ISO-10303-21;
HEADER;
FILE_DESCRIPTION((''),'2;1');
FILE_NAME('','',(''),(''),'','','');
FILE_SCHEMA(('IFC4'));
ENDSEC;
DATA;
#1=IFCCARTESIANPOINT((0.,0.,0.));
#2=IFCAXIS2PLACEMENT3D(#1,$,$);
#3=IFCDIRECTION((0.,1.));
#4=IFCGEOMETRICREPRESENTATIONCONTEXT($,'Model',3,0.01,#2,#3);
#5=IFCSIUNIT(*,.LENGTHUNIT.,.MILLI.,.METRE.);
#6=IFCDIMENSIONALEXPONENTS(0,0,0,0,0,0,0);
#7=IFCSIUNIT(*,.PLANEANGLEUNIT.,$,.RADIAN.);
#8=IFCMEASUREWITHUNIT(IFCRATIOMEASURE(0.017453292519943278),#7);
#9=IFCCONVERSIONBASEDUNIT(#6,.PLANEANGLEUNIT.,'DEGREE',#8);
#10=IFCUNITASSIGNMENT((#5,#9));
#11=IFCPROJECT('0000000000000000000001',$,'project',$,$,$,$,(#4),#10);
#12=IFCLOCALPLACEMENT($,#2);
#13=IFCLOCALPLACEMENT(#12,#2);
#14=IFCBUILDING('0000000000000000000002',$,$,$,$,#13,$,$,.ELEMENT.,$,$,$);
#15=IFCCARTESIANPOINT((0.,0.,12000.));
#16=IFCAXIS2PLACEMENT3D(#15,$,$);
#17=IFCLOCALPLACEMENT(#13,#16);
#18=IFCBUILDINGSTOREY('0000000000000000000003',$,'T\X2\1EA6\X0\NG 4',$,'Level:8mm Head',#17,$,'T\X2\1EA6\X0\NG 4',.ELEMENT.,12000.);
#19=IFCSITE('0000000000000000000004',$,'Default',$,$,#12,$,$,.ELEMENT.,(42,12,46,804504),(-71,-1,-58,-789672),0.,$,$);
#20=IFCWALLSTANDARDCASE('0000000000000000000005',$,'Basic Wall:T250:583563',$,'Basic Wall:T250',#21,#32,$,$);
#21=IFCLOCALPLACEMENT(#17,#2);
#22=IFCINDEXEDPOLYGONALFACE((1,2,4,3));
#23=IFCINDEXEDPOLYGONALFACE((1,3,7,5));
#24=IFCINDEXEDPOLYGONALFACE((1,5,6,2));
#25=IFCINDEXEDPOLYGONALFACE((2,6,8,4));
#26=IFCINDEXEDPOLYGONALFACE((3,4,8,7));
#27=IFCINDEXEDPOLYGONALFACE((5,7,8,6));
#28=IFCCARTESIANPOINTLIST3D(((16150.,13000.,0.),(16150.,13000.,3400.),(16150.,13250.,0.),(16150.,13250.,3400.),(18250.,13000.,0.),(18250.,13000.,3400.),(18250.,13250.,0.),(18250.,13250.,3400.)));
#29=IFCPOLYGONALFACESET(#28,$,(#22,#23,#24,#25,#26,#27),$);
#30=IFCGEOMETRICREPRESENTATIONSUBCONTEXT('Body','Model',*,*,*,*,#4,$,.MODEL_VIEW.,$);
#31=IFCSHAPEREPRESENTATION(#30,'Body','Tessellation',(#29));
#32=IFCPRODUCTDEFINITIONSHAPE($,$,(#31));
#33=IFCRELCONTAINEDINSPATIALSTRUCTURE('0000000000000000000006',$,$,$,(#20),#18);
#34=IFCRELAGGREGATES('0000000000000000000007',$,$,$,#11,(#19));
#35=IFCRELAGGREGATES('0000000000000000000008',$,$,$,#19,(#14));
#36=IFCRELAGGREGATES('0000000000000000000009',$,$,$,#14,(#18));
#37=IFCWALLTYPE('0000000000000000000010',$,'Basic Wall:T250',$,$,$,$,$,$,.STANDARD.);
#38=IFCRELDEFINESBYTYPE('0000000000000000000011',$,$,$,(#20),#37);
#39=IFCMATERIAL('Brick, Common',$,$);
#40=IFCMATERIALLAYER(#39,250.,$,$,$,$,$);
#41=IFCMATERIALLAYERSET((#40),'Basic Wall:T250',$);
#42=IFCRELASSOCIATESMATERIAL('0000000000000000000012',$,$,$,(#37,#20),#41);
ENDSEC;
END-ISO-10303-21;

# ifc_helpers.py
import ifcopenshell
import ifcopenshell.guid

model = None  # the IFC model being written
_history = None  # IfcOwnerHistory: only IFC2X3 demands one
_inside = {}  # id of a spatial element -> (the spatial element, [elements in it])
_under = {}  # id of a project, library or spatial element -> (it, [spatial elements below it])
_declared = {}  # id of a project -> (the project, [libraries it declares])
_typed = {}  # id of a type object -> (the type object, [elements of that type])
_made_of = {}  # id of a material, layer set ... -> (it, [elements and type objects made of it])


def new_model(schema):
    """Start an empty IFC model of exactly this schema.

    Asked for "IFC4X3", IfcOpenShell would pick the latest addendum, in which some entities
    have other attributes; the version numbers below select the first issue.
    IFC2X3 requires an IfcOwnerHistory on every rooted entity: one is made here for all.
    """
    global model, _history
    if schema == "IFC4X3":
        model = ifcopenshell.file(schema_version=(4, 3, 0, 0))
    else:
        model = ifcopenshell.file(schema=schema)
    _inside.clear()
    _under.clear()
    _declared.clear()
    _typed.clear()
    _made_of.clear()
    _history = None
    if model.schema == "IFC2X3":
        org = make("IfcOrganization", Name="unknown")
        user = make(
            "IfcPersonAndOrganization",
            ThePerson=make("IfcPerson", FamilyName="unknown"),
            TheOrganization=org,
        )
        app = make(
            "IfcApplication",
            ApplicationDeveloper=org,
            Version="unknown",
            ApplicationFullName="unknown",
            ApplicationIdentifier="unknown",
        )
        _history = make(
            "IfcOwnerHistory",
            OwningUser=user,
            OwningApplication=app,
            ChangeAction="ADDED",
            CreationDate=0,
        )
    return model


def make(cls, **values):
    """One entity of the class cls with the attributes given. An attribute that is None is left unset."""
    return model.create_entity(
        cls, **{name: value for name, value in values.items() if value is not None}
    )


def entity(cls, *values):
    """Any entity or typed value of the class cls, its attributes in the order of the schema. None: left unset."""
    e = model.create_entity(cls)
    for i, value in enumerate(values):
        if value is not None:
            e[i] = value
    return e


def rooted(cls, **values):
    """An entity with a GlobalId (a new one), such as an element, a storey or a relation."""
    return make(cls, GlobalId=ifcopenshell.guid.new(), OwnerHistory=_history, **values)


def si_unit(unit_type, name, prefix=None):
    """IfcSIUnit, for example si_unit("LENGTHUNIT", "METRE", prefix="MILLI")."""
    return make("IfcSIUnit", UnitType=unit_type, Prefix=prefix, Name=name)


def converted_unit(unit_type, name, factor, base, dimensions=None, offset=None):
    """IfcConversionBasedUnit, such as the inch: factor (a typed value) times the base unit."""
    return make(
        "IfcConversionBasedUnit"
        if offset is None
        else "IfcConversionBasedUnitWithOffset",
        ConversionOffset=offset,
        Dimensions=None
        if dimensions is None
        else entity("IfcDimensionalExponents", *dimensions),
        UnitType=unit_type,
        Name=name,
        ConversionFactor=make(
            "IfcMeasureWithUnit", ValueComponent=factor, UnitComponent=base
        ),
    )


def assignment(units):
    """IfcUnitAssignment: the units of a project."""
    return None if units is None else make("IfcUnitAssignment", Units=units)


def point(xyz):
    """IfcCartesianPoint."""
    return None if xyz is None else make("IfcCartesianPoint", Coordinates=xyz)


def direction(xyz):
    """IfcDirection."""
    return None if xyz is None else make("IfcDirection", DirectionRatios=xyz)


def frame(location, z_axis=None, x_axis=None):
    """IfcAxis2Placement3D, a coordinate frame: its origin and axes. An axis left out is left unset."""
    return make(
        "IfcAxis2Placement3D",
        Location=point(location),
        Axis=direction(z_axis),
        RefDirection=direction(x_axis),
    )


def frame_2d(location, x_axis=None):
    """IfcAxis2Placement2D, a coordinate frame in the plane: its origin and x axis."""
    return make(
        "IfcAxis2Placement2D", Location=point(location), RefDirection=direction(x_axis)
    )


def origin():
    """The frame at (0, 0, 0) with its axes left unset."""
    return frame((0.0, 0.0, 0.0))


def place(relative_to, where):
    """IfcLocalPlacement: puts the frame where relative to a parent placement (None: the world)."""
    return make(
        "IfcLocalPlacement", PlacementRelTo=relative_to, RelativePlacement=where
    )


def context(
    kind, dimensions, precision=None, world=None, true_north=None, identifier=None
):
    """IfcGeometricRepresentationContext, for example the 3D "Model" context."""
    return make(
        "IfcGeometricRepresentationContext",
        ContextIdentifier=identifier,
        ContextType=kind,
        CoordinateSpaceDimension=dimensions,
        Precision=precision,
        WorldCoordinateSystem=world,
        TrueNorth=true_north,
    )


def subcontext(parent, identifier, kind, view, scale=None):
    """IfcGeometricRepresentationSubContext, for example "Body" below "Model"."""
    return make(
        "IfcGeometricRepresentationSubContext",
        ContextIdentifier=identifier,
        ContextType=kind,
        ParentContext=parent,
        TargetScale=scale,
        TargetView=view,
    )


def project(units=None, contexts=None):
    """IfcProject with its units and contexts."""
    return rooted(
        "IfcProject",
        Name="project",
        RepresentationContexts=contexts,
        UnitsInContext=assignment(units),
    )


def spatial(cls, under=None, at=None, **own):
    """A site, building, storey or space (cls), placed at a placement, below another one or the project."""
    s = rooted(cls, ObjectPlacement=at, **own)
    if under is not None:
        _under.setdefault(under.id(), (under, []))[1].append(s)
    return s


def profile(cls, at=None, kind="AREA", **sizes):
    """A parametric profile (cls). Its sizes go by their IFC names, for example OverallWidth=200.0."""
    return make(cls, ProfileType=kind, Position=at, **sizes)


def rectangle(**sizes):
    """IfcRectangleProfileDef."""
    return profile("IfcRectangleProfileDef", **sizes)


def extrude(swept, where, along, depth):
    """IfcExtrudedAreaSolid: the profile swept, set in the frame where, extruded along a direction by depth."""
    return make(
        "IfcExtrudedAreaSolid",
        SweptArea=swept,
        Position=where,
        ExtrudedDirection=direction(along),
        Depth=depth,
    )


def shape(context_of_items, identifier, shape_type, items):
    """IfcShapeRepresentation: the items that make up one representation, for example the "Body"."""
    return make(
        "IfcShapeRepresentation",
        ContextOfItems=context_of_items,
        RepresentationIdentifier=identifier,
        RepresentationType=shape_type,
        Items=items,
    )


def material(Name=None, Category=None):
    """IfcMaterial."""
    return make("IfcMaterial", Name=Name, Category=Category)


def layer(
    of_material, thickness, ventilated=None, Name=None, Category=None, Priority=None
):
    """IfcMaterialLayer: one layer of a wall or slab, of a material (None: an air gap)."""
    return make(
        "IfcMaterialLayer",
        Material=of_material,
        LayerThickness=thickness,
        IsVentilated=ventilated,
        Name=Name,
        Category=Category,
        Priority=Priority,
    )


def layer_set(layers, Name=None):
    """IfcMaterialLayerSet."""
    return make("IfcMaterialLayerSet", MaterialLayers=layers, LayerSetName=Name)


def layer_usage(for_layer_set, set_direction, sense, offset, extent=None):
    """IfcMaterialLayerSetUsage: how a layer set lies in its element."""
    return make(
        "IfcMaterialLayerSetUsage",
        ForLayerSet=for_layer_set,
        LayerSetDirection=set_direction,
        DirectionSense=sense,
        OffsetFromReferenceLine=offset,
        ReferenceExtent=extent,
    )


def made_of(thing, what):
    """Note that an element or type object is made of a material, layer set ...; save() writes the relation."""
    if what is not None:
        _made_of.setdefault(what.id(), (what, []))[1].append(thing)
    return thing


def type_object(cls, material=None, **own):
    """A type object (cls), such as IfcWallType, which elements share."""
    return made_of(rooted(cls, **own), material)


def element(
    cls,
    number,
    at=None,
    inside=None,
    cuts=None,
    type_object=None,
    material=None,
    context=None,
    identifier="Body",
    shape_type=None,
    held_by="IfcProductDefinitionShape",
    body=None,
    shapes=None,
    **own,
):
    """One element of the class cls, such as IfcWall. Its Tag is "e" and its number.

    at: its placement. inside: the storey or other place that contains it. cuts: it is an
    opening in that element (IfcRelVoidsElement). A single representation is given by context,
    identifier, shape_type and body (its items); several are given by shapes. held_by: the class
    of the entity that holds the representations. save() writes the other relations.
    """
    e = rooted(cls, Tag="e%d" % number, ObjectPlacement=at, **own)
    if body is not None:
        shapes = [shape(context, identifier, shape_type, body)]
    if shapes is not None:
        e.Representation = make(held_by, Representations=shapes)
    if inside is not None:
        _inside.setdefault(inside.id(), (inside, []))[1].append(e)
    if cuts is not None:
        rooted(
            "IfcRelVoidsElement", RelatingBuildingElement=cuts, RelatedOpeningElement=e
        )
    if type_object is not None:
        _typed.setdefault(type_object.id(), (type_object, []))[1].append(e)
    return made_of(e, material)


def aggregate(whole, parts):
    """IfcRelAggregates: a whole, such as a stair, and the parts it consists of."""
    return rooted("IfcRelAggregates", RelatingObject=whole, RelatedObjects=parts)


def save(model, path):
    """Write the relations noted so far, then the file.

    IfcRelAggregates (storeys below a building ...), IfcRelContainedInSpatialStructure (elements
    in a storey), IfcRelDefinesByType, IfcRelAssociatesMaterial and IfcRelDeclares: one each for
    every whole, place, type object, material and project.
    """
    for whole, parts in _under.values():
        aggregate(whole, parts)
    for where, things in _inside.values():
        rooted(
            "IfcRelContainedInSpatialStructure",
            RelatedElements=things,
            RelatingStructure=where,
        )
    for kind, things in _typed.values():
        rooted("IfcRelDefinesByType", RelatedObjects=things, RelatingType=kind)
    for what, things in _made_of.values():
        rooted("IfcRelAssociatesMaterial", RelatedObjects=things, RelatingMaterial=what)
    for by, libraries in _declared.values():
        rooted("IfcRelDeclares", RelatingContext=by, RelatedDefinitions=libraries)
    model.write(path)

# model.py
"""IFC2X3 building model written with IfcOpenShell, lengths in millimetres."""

from ifc_helpers import new_model, entity, si_unit, converted_unit, direction, frame, frame_2d, origin, place, context, subcontext, project, spatial, rectangle, extrude, material, layer, layer_set, layer_usage, type_object, element, save


model = new_model("IFC2X3")

# Units and contexts
model_context = context("Model", 3, precision=0.01, world=origin(), true_north=direction((0.0, 1.0)))
body_context = subcontext(model_context, "Body", "Model", "MODEL_VIEW")
ifc_project = project(units=[si_unit("LENGTHUNIT", "METRE", prefix="MILLI"), converted_unit("PLANEANGLEUNIT", "DEGREE", entity("IfcRatioMeasure", 0.017453292519943278), si_unit("PLANEANGLEUNIT", "RADIAN"), dimensions=[0, 0, 0, 0, 0, 0, 0])], contexts=[model_context])

# Site, building, storey
site_placement = place(None, origin())
site = spatial("IfcSite", under=ifc_project, at=site_placement, Name="Default", CompositionType="ELEMENT", RefLatitude=(42, 12, 46, 804504), RefLongitude=(-71, -1, -58, -789672), RefElevation=0.0)
building_placement = place(site_placement, origin())
building = spatial("IfcBuilding", under=site, at=building_placement, CompositionType="ELEMENT")
storey_placement = place(building_placement, frame((0.0, 0.0, 12000.0)))
storey = spatial("IfcBuildingStorey", under=building, at=storey_placement, Name="TẦNG 4", ObjectType="Level:8mm Head", LongName="TẦNG 4", CompositionType="ELEMENT", Elevation=12000.0)

# Shared definitions
ifc_material_1 = material(Name="Brick, Common")

# Wall
ifc_layer_1 = layer(ifc_material_1, 250.0)
ifc_layer_set_1 = layer_set([ifc_layer_1], Name="Basic Wall:T250")
ifc_layer_usage_1 = layer_usage(ifc_layer_set_1, "AXIS2", "POSITIVE", -125.0)
wall_type_1 = type_object("IfcWallType", Name="Basic Wall:T250", PredefinedType="STANDARD", material=ifc_layer_set_1)
wall_1_placement = place(storey_placement, frame((16150.0, 13125.0, 0.0)))
element("IfcWallStandardCase", 1, at=wall_1_placement, inside=storey, type_object=wall_type_1, material=ifc_layer_usage_1, Name="Basic Wall:T250:583563", ObjectType="Basic Wall:T250", context=body_context, shape_type="SweptSolid", body=[
    extrude(rectangle(XDim=2100.0, YDim=250.0, at=frame_2d((1050.0, 0.0), x_axis=(-1.0, 0.0))), origin(), (0.0, 0.0, 1.0), 3400.0),
])

save(model, "model.ifc")
